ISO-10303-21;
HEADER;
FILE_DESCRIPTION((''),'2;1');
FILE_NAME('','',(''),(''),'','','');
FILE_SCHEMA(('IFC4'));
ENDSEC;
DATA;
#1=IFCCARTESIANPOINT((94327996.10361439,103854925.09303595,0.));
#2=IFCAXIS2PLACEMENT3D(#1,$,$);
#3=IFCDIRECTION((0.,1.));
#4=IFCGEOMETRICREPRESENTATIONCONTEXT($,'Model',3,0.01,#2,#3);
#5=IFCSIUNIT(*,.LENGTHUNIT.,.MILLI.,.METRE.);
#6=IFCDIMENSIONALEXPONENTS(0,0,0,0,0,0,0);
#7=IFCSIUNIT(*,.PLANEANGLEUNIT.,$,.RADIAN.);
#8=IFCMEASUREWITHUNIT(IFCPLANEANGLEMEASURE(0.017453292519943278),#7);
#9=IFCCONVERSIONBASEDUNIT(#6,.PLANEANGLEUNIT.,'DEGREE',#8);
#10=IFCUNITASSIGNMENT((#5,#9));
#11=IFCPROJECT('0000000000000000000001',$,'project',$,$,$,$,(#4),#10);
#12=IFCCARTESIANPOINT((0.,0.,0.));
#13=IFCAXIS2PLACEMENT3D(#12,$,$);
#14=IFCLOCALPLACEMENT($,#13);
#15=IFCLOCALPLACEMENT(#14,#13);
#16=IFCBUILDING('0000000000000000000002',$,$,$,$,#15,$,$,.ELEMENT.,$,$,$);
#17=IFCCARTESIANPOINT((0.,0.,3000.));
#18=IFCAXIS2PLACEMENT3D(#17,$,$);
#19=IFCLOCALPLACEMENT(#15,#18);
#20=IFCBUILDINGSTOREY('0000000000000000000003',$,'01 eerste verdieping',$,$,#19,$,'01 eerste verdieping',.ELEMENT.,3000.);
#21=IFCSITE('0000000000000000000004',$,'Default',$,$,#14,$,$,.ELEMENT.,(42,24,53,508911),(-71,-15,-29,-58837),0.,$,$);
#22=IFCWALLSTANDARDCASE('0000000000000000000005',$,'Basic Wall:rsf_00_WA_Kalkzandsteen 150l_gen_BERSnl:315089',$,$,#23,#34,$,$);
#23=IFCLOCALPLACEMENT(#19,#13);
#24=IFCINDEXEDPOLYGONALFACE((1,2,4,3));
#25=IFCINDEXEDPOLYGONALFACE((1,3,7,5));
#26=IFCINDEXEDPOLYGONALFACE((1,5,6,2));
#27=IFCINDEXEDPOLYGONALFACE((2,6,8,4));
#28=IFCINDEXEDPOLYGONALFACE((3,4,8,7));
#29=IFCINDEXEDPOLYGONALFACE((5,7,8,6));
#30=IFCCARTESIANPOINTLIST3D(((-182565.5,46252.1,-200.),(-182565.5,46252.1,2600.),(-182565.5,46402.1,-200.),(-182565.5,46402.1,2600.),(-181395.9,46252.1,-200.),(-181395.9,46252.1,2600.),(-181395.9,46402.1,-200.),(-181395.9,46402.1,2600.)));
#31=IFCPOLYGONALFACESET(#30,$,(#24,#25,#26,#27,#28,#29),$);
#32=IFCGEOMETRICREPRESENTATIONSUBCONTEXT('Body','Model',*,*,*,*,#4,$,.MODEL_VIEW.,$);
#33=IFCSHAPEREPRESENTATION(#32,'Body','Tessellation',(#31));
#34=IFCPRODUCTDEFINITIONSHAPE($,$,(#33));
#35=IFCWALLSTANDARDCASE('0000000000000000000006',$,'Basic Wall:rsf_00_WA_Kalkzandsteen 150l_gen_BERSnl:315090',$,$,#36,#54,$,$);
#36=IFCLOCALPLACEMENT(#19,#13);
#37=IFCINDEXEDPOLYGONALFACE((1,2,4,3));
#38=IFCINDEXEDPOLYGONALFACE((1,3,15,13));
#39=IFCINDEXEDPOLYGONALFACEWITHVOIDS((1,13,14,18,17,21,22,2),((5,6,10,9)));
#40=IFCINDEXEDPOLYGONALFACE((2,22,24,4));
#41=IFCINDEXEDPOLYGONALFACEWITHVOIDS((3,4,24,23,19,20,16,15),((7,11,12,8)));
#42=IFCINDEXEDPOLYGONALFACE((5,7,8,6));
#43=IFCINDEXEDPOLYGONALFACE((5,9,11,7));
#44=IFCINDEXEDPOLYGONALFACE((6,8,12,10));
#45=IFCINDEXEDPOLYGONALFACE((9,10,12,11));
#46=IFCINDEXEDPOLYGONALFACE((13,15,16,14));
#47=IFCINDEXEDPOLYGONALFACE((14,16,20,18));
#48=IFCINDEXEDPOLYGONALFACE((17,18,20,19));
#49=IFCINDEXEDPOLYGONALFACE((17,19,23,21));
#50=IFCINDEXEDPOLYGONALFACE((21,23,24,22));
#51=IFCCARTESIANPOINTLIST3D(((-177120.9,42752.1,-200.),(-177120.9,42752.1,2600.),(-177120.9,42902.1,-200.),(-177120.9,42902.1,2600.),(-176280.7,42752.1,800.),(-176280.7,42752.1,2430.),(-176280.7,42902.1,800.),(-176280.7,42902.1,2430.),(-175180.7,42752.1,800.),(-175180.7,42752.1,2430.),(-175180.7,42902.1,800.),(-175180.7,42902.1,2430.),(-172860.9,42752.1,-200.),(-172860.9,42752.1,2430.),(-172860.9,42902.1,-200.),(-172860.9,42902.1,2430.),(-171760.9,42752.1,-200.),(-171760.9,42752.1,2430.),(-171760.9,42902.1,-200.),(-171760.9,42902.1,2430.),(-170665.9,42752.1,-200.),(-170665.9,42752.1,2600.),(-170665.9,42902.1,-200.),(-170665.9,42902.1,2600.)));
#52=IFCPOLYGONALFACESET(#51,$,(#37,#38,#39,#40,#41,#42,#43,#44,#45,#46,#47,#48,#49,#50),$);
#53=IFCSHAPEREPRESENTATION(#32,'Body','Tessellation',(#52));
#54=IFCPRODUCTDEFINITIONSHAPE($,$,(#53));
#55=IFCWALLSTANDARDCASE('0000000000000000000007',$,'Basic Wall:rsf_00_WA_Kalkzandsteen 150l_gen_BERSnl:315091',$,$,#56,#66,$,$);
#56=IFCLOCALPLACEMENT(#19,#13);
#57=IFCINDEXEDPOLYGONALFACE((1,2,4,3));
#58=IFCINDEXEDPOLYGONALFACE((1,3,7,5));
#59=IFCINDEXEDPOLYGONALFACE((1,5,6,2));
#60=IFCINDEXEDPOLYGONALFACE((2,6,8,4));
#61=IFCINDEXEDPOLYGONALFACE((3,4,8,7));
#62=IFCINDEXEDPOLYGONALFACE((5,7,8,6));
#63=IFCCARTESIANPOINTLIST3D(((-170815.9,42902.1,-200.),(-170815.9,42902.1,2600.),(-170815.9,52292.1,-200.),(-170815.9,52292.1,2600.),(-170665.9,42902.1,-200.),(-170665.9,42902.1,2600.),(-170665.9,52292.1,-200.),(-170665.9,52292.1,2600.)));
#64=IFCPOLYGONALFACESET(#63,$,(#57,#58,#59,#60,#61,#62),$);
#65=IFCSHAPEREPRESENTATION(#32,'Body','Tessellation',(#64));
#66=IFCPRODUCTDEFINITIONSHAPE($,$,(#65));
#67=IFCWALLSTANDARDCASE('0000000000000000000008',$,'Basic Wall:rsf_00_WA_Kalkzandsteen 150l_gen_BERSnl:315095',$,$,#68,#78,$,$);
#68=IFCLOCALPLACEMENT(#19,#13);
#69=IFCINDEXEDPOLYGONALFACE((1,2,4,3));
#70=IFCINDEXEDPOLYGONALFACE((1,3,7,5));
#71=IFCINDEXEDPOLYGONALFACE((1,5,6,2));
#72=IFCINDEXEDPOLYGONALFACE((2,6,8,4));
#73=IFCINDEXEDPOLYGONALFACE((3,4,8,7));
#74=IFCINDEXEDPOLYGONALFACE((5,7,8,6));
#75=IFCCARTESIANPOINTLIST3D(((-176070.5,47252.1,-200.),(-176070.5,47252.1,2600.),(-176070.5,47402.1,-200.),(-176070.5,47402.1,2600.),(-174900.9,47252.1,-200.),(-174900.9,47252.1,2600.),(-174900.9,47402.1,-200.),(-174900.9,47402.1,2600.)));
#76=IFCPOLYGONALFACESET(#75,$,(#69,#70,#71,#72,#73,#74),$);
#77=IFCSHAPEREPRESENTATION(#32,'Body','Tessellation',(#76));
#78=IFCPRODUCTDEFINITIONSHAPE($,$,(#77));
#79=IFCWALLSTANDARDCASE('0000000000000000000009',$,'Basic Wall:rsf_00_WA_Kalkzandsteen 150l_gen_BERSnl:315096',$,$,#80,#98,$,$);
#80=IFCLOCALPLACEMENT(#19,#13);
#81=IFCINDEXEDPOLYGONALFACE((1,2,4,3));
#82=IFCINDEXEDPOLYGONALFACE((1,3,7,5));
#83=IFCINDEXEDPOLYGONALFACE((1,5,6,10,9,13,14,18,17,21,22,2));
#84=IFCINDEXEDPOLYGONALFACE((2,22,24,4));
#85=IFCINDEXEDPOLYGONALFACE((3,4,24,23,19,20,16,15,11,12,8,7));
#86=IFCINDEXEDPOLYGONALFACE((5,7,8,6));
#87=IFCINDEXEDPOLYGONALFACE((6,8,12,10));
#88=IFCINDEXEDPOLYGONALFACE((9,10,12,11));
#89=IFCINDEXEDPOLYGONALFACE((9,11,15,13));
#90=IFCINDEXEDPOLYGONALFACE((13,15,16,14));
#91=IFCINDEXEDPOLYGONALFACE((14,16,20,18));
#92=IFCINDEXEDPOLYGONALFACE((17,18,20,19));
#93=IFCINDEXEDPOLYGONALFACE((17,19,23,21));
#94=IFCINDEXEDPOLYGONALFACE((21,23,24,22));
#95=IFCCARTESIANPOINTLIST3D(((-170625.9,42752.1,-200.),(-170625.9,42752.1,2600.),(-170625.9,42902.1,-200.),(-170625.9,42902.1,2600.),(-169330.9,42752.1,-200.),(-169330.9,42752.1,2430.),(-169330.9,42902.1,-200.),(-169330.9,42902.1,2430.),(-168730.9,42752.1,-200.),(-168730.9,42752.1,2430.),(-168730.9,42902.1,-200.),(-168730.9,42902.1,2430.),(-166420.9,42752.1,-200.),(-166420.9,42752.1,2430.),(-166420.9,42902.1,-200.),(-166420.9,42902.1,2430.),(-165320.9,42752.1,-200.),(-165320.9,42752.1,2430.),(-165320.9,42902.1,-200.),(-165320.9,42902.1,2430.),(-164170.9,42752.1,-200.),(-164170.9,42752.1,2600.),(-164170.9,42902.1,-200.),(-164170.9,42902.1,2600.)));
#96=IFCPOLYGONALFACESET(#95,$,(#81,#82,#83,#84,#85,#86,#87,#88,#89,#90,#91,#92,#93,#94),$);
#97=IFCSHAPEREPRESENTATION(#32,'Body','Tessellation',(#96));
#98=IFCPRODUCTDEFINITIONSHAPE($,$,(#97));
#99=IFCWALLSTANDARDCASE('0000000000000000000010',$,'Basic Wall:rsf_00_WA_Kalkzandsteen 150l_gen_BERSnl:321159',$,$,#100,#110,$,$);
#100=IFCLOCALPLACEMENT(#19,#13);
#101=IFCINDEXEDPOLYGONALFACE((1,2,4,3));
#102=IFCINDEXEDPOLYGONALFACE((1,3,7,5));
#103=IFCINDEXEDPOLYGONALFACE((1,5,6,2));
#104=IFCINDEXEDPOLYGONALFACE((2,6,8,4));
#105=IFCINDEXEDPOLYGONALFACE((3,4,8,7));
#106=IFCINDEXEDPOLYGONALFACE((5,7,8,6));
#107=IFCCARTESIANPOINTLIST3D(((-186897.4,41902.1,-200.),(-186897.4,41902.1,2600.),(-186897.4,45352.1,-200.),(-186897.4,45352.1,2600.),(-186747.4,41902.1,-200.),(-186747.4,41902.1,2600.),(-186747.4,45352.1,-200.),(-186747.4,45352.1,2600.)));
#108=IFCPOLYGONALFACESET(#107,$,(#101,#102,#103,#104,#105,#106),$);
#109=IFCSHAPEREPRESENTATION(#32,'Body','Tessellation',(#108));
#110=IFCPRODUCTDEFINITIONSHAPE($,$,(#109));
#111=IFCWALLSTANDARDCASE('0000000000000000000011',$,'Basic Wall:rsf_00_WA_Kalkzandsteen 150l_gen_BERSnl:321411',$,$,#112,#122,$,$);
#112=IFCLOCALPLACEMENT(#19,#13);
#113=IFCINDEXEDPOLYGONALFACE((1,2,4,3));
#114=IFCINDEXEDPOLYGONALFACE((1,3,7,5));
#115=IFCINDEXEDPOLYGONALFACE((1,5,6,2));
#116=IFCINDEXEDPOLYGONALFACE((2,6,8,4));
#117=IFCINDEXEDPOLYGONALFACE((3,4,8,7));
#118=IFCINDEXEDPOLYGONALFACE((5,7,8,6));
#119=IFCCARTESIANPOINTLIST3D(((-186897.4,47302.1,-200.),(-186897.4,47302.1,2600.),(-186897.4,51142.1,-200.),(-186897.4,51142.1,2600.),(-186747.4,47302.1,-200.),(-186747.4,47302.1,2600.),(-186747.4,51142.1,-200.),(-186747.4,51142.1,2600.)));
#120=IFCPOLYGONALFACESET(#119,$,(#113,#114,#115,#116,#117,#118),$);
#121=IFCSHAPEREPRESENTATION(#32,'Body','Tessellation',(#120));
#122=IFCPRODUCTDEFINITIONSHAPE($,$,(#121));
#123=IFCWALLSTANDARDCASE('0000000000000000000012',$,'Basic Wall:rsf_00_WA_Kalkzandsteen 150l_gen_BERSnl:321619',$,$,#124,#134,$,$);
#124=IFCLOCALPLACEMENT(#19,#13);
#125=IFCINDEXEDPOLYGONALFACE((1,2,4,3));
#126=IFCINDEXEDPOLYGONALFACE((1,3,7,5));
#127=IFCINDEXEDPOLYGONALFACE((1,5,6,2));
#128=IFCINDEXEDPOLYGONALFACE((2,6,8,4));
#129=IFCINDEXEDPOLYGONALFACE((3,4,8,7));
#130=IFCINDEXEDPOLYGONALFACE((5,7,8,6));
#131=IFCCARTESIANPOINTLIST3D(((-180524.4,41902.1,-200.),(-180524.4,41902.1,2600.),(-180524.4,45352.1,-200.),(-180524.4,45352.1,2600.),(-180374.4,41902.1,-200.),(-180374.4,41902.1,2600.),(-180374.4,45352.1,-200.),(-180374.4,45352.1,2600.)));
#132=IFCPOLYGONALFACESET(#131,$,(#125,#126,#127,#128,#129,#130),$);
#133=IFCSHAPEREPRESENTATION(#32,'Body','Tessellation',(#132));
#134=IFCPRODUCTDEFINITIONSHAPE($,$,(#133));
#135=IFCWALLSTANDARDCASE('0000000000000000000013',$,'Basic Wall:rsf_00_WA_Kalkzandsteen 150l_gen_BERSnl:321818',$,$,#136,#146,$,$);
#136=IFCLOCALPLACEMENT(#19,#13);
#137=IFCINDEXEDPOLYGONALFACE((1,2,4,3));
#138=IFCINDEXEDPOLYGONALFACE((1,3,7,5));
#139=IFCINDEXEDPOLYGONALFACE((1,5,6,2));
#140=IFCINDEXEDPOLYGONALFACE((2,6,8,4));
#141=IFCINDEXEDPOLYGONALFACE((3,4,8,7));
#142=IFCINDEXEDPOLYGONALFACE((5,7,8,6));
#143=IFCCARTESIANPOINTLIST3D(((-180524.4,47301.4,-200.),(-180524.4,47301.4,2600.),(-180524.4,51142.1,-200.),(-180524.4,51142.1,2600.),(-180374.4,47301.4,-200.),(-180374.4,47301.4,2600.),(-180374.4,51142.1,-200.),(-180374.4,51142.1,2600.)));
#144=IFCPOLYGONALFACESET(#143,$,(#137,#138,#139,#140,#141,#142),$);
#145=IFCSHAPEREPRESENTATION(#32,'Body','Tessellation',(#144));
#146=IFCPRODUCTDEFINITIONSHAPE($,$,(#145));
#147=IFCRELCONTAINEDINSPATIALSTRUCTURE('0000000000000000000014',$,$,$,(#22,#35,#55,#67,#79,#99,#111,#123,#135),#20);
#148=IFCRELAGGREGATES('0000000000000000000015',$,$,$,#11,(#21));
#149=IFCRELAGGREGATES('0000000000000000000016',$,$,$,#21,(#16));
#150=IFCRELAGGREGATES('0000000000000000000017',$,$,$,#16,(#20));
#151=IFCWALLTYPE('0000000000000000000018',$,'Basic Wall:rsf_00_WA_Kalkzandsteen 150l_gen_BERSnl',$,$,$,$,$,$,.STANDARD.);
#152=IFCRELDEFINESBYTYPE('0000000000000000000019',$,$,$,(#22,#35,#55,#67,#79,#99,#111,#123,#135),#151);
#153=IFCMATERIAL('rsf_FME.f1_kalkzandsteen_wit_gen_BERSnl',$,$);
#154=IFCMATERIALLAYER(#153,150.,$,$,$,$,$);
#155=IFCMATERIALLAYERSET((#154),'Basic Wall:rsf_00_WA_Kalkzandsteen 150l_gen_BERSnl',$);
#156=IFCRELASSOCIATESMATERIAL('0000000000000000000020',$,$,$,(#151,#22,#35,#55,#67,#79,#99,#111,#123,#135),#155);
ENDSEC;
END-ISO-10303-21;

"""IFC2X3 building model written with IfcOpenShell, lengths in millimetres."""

from ifc_helpers import new_model, entity, si_unit, converted_unit, direction, frame, frame_2d, origin, origin_2d_with_axis, place, context, subcontext, project, spatial, polyline, rectangle, extrude, clip, bounded_halfspace, material, layer, layer_set, layer_usage, type_object, element, save


model = new_model("IFC2X3")

# Units and contexts
model_context = context("Model", 3, precision=0.01, world=frame((94327996.10361439, 103854925.09303595, 0.0)), true_north=direction((0.0, 1.0)))
body_context = subcontext(model_context, "Body", "Model", "MODEL_VIEW")
ifc_project = project(units=[si_unit("LENGTHUNIT", "METRE", prefix="MILLI"), converted_unit("PLANEANGLEUNIT", "DEGREE", entity("IfcPlaneAngleMeasure", 0.017453292519943278), si_unit("PLANEANGLEUNIT", "RADIAN"), dimensions=[0, 0, 0, 0, 0, 0, 0])], contexts=[model_context])

# Site, building, storey
site_placement = place(None, origin())
site = spatial("IfcSite", under=ifc_project, at=site_placement, Name="Default", CompositionType="ELEMENT", RefLatitude=(42, 24, 53, 508911), RefLongitude=(-71, -15, -29, -58837), RefElevation=0.0)
building_placement = place(site_placement, origin())
building = spatial("IfcBuilding", under=site, at=building_placement, CompositionType="ELEMENT")
storey_placement = place(building_placement, frame((0.0, 0.0, 3000.0)))
storey = spatial("IfcBuildingStorey", under=building, at=storey_placement, Name="01 eerste verdieping", LongName="01 eerste verdieping", CompositionType="ELEMENT", Elevation=3000.0)

# Shared definitions
ifc_material = material(Name="rsf_FME.f1_kalkzandsteen_wit_gen_BERSnl")
ifc_layer = layer(ifc_material, 150.0)
ifc_layer_set = layer_set([ifc_layer], Name="Basic Wall:rsf_00_WA_Kalkzandsteen 150l_gen_BERSnl")
wall_type = type_object("IfcWallType", Name="Basic Wall:rsf_00_WA_Kalkzandsteen 150l_gen_BERSnl", PredefinedType="STANDARD", material=ifc_layer_set)

# Wall
ifc_layer_usage_1 = layer_usage(ifc_layer_set, "AXIS2", "POSITIVE", -75.0)
wall_1_placement = place(storey_placement, frame((-181395.9, 46327.1, -200.0), z_axis=(0.0, 0.0, 1.0), x_axis=(-1.0, 0.0, 0.0)))
element("IfcWallStandardCase", 1, at=wall_1_placement, inside=storey, type_object=wall_type, material=ifc_layer_usage_1, Name="Basic Wall:rsf_00_WA_Kalkzandsteen 150l_gen_BERSnl:315089", context=body_context, shape_type="Clipping", body=[
    clip(extrude(rectangle(XDim=1169.6, YDim=150.0, at=frame_2d((584.8, 0.0), x_axis=(-1.0, 0.0))), origin(), (0.0, 0.0, 1.0), 2800.0), bounded_halfspace(frame((0.0, -75.0, 2800.0), z_axis=(0.0, 0.0, -1.0), x_axis=(0.0, -1.0, 0.0)), True, frame((0.0, -75.0, 2800.0)), polyline([(0.0, 0.0), (1169.6, 0.0), (1169.6, 150.0), (0.0, 150.0), (0.0, 0.0)]))),
])

# Wall, openings
ifc_layer_usage_2 = layer_usage(ifc_layer_set, "AXIS2", "NEGATIVE", 75.0)
wall_2_placement = place(storey_placement, frame((-177120.9, 42827.1, -200.0)))
wall_2 = element("IfcWallStandardCase", 2, at=wall_2_placement, inside=storey, type_object=wall_type, material=ifc_layer_usage_2, Name="Basic Wall:rsf_00_WA_Kalkzandsteen 150l_gen_BERSnl:315090", context=body_context, shape_type="Clipping", body=[
    clip(extrude(rectangle(XDim=6455.0, YDim=150.0, at=frame_2d((3227.5, 0.0), x_axis=(1.0, 0.0))), origin(), (0.0, 0.0, 1.0), 2800.0), bounded_halfspace(frame((0.0, -75.0, 2800.0), z_axis=(0.0, 0.0, -1.0), x_axis=(0.0, 1.0, 0.0)), True, frame((0.0, -75.0, 2800.0)), polyline([(0.0, 0.0), (6455.0, 0.0), (6455.0, 150.0), (6305.0, 150.0), (3241.5, 150.0), (3091.5, 150.0), (150.0, 150.0), (0.0, 150.0), (0.0, 0.0)]))),
])
opening_1_placement = place(wall_2_placement, frame((177120.9, -42827.1, 200.0)))
element("IfcOpeningElement", 3, at=opening_1_placement, cuts=wall_2, ObjectType="Opening", context=body_context, shape_type="SweptSolid", body=[
    extrude(rectangle(XDim=2630.0, YDim=1100.0, at=frame_2d((0.0, 0.0), x_axis=(1.0, 0.0))), frame((-172310.9, 41378.1, 1115.0), z_axis=(0.0, 1.0, 0.0), x_axis=(0.0, 0.0, 1.0)), (0.0, 0.0, 1.0), 3048.0),
])
opening_2_placement = place(wall_2_placement, frame((177120.9, -42827.1, 200.0)))
element("IfcOpeningElement", 4, at=opening_2_placement, cuts=wall_2, ObjectType="Opening", context=body_context, shape_type="SweptSolid", body=[
    extrude(rectangle(XDim=1630.0, YDim=1100.0, at=frame_2d((0.0, 0.0), x_axis=(1.0, 0.0))), frame((-175730.7, 41378.1, 1615.0), z_axis=(0.0, 1.0, 0.0), x_axis=(0.0, 0.0, 1.0)), (0.0, 0.0, 1.0), 3048.0),
])

# Walls
ifc_layer_usage_3 = layer_usage(ifc_layer_set, "AXIS2", "NEGATIVE", 75.0)
wall_3_placement = place(storey_placement, frame((-170740.9, 42902.1, -200.0), z_axis=(0.0, 0.0, 1.0), x_axis=(0.0, 1.0, 0.0)))
element("IfcWallStandardCase", 5, at=wall_3_placement, inside=storey, type_object=wall_type, material=ifc_layer_usage_3, Name="Basic Wall:rsf_00_WA_Kalkzandsteen 150l_gen_BERSnl:315091", context=body_context, shape_type="Clipping", body=[
    clip(extrude(rectangle(XDim=9390.0, YDim=150.0, at=frame_2d((4695.0, 0.0), x_axis=(-1.0, 0.0))), origin(), (0.0, 0.0, 1.0), 2800.0), bounded_halfspace(frame((0.0, -75.0, 2800.0), z_axis=(0.0, 0.0, -1.0), x_axis=(1.0, 0.0, 0.0)), True, frame((0.0, -75.0, 2800.0)), polyline([(0.0, 0.0), (9390.0, 0.0), (9390.0, 150.0), (9240.0, 150.0), (0.0, 150.0), (0.0, 0.0)]))),
])
ifc_layer_usage_4 = layer_usage(ifc_layer_set, "AXIS2", "POSITIVE", -75.0)
wall_4_placement = place(storey_placement, frame((-174900.9, 47327.1, -200.0), z_axis=(0.0, 0.0, 1.0), x_axis=(-1.0, 0.0, 0.0)))
element("IfcWallStandardCase", 6, at=wall_4_placement, inside=storey, type_object=wall_type, material=ifc_layer_usage_4, Name="Basic Wall:rsf_00_WA_Kalkzandsteen 150l_gen_BERSnl:315095", context=body_context, shape_type="Clipping", body=[
    clip(extrude(rectangle(XDim=1169.6, YDim=150.0, at=frame_2d((584.8, 0.0), x_axis=(-1.0, 0.0))), origin(), (0.0, 0.0, 1.0), 2800.0), bounded_halfspace(frame((0.0, -75.0, 2800.0), z_axis=(0.0, 0.0, -1.0), x_axis=(0.0, -1.0, 0.0)), True, frame((0.0, -75.0, 2800.0)), polyline([(0.0, 0.0), (1169.6, 0.0), (1169.6, 150.0), (0.0, 150.0), (0.0, 0.0)]))),
])

# Wall, openings
ifc_layer_usage_5 = layer_usage(ifc_layer_set, "AXIS2", "NEGATIVE", 75.0)
wall_5_placement = place(storey_placement, frame((-170625.9, 42827.1, -200.0)))
wall_5 = element("IfcWallStandardCase", 7, at=wall_5_placement, inside=storey, type_object=wall_type, material=ifc_layer_usage_5, Name="Basic Wall:rsf_00_WA_Kalkzandsteen 150l_gen_BERSnl:315096", context=body_context, shape_type="Clipping", body=[
    clip(extrude(rectangle(XDim=6455.0, YDim=150.0, at=frame_2d((3227.5, 0.0), x_axis=(-1.0, 0.0))), origin(), (0.0, 0.0, 1.0), 2800.0), bounded_halfspace(frame((0.0, -75.0, 2800.0), z_axis=(0.0, 0.0, -1.0), x_axis=(0.0, 1.0, 0.0)), True, frame((0.0, -75.0, 2800.0)), polyline([(0.0, 0.0), (6455.0, 0.0), (6455.0, 150.0), (6305.0, 150.0), (3241.5, 150.0), (3091.5, 150.0), (150.0, 150.0), (0.0, 150.0), (0.0, 0.0)]))),
])
opening_3_placement = place(wall_5_placement, frame((170625.9, -42827.1, 200.0)))
element("IfcOpeningElement", 8, at=opening_3_placement, cuts=wall_5, ObjectType="Opening", context=body_context, shape_type="SweptSolid", body=[
    extrude(rectangle(XDim=2630.0, YDim=600.0, at=origin_2d_with_axis()), frame((-169030.9, 41378.1, 1115.0), z_axis=(0.0, 1.0, 0.0), x_axis=(0.0, 0.0, 1.0)), (0.0, 0.0, 1.0), 3048.0),
])
opening_4_placement = place(wall_5_placement, frame((170625.9, -42827.1, 200.0)))
element("IfcOpeningElement", 9, at=opening_4_placement, cuts=wall_5, ObjectType="Opening", context=body_context, shape_type="SweptSolid", body=[
    extrude(rectangle(XDim=2630.0, YDim=1100.0, at=frame_2d((0.0, 0.0), x_axis=(0.0, 1.0))), frame((-165870.9, 41228.1, 1115.0), z_axis=(0.0, 1.0, 0.0), x_axis=(-1.0, 0.0, 0.0)), (0.0, 0.0, 1.0), 3048.0),
])

# Walls
ifc_layer_usage_6 = layer_usage(ifc_layer_set, "AXIS2", "POSITIVE", -75.0)
wall_6_placement = place(storey_placement, frame((-186822.4, 41902.1, -200.0), z_axis=(0.0, 0.0, 1.0), x_axis=(0.0, 1.0, 0.0)))
element("IfcWallStandardCase", 10, at=wall_6_placement, inside=storey, type_object=wall_type, material=ifc_layer_usage_6, Name="Basic Wall:rsf_00_WA_Kalkzandsteen 150l_gen_BERSnl:321159", context=body_context, shape_type="Clipping", body=[
    clip(extrude(rectangle(XDim=3450.0, YDim=150.0, at=frame_2d((1725.0, 0.0), x_axis=(-1.0, 0.0))), origin(), (0.0, 0.0, 1.0), 2800.0), bounded_halfspace(frame((0.0, -75.0, 2800.0), z_axis=(0.0, 0.0, -1.0), x_axis=(1.0, 0.0, 0.0)), True, frame((0.0, -75.0, 2800.0)), polyline([(0.0, 0.0), (3450.0, 0.0), (3450.0, 150.0), (0.0, 150.0), (0.0, 0.0)]))),
])
ifc_layer_usage_7 = layer_usage(ifc_layer_set, "AXIS2", "NEGATIVE", 75.0)
wall_7_placement = place(storey_placement, frame((-186822.4, 51142.1, -200.0), z_axis=(0.0, 0.0, 1.0), x_axis=(0.0, -1.0, 0.0)))
element("IfcWallStandardCase", 11, at=wall_7_placement, inside=storey, type_object=wall_type, material=ifc_layer_usage_7, Name="Basic Wall:rsf_00_WA_Kalkzandsteen 150l_gen_BERSnl:321411", context=body_context, shape_type="SweptSolid", body=[
    extrude(rectangle(XDim=3840.0, YDim=150.0, at=frame_2d((1920.0, 0.0), x_axis=(-1.0, 0.0))), origin(), (0.0, 0.0, 1.0), 2800.0),
])
ifc_layer_usage_8 = layer_usage(ifc_layer_set, "AXIS2", "POSITIVE", -75.0)
wall_8_placement = place(storey_placement, frame((-180449.4, 41902.1, -200.0), z_axis=(0.0, 0.0, 1.0), x_axis=(0.0, 1.0, 0.0)))
element("IfcWallStandardCase", 12, at=wall_8_placement, inside=storey, type_object=wall_type, material=ifc_layer_usage_8, Name="Basic Wall:rsf_00_WA_Kalkzandsteen 150l_gen_BERSnl:321619", context=body_context, shape_type="Clipping", body=[
    clip(extrude(rectangle(XDim=3450.0, YDim=150.0, at=frame_2d((1725.0, 0.0), x_axis=(-1.0, 0.0))), origin(), (0.0, 0.0, 1.0), 2800.0), bounded_halfspace(frame((0.0, -75.0, 2800.0), z_axis=(0.0, 0.0, -1.0), x_axis=(1.0, 0.0, 0.0)), True, frame((0.0, -75.0, 2800.0)), polyline([(0.0, 0.0), (3450.0, 0.0), (3450.0, 150.0), (0.0, 150.0), (0.0, 0.0)]))),
])
ifc_layer_usage_9 = layer_usage(ifc_layer_set, "AXIS2", "NEGATIVE", 75.0)
wall_9_placement = place(storey_placement, frame((-180449.4, 51142.1, -200.0), z_axis=(0.0, 0.0, 1.0), x_axis=(0.0, -1.0, 0.0)))
element("IfcWallStandardCase", 13, at=wall_9_placement, inside=storey, type_object=wall_type, material=ifc_layer_usage_9, Name="Basic Wall:rsf_00_WA_Kalkzandsteen 150l_gen_BERSnl:321818", context=body_context, shape_type="SweptSolid", body=[
    extrude(rectangle(XDim=3840.6, YDim=150.0, at=frame_2d((1920.3, 0.0), x_axis=(-1.0, 0.0))), origin(), (0.0, 0.0, 1.0), 2800.0),
])

save(model, "model.ifc")
